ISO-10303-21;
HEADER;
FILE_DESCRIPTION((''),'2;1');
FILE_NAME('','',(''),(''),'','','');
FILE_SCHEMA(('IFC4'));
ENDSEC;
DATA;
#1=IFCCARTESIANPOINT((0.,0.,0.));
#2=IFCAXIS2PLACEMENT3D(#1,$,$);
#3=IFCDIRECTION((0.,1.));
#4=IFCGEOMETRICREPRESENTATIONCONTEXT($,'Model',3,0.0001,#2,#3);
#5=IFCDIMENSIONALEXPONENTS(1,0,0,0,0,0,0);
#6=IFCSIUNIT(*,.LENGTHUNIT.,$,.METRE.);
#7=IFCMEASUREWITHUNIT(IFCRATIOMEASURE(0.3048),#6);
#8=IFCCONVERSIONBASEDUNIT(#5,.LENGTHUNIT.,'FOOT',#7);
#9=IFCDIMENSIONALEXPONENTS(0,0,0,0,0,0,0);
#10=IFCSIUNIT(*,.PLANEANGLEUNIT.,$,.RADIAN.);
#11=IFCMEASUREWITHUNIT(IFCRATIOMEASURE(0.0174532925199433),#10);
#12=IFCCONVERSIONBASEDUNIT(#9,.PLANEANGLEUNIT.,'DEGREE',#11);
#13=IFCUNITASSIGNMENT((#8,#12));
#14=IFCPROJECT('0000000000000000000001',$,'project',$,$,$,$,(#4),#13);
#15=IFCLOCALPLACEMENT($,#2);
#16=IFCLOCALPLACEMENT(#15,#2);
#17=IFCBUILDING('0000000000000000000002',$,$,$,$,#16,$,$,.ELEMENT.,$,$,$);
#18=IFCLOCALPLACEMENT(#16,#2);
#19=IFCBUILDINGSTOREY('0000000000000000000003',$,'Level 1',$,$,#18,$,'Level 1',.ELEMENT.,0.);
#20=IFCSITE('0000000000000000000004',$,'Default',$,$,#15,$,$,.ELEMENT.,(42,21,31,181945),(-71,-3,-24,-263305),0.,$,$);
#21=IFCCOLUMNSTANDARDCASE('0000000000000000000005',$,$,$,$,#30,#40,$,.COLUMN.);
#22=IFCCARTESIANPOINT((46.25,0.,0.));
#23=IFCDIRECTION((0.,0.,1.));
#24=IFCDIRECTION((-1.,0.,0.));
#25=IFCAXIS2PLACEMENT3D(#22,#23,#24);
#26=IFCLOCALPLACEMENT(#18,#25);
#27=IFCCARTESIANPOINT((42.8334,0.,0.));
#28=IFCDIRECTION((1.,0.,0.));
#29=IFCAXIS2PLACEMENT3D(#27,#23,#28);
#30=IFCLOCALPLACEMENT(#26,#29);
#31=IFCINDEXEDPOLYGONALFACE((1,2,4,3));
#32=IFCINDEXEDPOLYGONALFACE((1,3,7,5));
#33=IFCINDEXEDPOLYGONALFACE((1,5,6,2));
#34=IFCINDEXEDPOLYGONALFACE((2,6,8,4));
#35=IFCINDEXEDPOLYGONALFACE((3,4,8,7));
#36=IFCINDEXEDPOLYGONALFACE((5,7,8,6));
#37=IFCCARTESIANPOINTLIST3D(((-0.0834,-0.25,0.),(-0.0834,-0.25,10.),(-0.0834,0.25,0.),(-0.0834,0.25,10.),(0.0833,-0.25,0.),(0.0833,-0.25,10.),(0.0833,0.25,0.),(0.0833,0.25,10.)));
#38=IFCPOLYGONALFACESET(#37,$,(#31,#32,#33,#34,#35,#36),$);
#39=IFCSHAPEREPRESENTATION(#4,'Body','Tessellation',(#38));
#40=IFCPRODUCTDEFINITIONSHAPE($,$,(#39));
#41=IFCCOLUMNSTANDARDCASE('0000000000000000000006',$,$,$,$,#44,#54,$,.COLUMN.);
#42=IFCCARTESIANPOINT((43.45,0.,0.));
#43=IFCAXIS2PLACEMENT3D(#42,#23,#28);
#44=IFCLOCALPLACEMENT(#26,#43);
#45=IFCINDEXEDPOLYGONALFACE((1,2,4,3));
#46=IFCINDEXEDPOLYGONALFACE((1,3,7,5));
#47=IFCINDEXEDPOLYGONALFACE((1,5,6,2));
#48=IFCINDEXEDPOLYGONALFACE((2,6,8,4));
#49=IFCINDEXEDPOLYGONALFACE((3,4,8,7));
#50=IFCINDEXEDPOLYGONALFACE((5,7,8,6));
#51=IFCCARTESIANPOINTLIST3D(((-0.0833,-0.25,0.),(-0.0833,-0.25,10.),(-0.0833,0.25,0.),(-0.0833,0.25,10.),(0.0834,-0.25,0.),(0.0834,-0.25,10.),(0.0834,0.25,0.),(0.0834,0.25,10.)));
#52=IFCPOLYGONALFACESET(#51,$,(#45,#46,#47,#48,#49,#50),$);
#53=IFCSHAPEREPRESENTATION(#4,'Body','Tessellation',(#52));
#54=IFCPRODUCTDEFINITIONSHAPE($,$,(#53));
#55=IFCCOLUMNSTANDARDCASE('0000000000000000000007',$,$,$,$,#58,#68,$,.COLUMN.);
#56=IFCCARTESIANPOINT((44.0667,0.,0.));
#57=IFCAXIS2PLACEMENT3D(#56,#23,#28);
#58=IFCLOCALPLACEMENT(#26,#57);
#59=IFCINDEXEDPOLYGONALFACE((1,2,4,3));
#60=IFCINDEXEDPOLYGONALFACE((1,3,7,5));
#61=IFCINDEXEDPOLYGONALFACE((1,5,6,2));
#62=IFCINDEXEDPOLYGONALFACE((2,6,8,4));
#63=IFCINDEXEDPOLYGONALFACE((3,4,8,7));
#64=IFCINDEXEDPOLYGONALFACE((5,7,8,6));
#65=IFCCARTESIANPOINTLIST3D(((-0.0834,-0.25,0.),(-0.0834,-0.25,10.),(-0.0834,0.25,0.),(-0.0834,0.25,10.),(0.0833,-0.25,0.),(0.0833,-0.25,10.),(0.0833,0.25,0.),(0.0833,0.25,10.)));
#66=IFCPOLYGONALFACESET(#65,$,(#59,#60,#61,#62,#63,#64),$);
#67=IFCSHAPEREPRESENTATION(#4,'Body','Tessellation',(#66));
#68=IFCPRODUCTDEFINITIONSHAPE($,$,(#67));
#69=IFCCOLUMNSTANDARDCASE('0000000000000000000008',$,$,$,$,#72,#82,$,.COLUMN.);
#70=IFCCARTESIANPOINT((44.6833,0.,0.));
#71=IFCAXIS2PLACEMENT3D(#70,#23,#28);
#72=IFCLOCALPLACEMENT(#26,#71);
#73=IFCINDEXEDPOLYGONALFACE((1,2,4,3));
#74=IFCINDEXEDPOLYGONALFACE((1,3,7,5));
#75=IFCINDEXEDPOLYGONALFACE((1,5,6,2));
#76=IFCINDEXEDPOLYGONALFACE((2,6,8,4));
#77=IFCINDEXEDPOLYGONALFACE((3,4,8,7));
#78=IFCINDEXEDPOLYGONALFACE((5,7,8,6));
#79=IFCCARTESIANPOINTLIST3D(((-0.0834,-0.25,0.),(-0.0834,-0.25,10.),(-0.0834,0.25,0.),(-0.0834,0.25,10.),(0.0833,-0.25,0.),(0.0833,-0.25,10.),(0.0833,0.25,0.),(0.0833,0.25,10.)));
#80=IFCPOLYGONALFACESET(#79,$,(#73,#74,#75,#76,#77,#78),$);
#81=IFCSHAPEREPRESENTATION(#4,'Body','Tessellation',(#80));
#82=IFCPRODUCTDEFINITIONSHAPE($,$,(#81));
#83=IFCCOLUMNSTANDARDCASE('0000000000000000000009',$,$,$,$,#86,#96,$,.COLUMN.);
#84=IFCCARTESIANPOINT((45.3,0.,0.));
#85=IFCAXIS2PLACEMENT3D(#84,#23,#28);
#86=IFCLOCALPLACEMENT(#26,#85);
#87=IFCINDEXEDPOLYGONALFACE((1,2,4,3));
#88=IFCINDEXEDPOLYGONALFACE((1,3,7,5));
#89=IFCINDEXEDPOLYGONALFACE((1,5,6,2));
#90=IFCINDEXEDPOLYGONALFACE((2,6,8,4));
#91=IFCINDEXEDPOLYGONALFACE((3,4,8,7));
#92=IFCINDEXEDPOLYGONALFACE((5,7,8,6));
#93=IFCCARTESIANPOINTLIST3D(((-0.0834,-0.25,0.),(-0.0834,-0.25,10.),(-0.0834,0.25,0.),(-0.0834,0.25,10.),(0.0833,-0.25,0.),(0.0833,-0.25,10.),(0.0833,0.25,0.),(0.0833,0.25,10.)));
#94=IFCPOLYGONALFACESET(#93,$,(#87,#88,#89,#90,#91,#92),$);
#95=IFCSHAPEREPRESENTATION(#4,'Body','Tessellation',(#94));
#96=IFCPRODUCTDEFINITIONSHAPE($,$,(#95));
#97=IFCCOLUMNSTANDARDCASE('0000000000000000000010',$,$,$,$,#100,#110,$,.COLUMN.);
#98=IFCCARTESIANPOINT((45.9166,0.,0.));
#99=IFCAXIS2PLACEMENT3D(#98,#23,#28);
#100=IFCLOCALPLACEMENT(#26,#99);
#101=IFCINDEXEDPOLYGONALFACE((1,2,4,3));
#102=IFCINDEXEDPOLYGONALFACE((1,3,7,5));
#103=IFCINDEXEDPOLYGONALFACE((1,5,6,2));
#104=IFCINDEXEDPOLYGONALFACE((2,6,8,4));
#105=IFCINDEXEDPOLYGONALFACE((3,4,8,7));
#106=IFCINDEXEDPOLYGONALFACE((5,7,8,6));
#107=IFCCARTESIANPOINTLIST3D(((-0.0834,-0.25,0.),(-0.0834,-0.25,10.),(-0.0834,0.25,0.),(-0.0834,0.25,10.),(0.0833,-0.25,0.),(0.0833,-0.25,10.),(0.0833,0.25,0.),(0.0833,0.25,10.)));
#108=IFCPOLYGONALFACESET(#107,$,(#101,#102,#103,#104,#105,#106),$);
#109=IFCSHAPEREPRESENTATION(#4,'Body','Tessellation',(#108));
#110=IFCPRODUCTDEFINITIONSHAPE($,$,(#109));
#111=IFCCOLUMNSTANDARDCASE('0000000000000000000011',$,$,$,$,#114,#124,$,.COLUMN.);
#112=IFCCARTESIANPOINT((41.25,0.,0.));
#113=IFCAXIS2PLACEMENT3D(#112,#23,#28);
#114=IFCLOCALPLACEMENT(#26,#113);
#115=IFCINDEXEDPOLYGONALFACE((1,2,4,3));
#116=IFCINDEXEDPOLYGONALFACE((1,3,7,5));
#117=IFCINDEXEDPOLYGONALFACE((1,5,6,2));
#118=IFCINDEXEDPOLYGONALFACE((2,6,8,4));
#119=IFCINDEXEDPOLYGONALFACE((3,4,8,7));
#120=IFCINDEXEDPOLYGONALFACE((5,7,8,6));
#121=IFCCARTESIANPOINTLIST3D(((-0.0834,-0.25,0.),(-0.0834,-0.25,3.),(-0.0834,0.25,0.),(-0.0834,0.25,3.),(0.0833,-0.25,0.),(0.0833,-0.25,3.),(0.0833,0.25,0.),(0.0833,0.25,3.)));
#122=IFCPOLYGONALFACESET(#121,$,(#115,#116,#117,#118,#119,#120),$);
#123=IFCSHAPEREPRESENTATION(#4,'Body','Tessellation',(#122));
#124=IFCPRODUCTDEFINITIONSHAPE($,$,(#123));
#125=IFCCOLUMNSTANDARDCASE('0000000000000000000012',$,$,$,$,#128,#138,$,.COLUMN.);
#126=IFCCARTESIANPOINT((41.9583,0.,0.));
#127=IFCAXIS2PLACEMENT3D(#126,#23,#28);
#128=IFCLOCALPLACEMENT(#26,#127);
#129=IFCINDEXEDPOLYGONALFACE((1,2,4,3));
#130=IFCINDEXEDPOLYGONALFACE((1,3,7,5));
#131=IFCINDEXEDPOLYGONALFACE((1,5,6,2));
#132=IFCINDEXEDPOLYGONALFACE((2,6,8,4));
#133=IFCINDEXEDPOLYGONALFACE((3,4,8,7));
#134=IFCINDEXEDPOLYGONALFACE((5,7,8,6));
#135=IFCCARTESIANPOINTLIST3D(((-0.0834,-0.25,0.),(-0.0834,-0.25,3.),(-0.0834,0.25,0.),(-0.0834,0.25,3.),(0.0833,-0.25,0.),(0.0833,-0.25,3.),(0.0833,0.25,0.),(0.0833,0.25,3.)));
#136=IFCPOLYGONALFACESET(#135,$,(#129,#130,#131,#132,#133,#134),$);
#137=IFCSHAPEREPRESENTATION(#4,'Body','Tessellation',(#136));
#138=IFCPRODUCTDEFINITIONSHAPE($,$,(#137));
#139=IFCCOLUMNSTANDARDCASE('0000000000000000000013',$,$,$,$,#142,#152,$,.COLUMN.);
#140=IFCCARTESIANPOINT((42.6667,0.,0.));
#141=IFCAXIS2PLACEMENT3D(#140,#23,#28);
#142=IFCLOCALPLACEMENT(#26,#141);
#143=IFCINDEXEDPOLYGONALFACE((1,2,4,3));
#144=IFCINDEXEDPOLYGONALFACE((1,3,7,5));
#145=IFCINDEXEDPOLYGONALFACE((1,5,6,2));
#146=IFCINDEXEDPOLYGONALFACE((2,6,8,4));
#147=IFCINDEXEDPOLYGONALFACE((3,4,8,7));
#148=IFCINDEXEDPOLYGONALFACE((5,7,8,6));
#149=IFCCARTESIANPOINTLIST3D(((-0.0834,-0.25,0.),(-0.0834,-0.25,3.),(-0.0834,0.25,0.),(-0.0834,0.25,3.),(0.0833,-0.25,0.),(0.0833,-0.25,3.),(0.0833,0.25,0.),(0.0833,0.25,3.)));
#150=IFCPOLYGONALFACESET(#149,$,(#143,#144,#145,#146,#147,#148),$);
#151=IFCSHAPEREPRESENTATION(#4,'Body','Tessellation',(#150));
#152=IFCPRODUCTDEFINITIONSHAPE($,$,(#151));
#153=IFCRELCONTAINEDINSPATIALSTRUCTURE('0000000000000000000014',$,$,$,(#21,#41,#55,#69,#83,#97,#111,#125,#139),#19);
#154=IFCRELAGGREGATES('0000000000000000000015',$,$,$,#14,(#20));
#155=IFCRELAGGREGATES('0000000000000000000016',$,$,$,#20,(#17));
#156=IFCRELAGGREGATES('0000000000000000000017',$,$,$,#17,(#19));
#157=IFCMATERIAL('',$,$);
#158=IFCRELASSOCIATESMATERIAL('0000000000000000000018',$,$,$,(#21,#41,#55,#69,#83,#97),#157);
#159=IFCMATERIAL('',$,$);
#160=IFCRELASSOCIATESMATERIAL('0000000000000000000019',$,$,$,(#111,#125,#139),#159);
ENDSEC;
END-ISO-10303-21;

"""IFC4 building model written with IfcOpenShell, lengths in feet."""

from ifc_helpers import new_model, entity, si_unit, converted_unit, direction, frame, origin, place, context, project, spatial, rectangle, extrude, material, element, save


model = new_model("IFC4")

# Units and contexts
model_context = context("Model", 3, precision=0.0001, world=origin(), true_north=direction((0.0, 1.0)))
ifc_project = project(units=[converted_unit("LENGTHUNIT", "FOOT", entity("IfcRatioMeasure", 0.3048), si_unit("LENGTHUNIT", "METRE"), dimensions=[1, 0, 0, 0, 0, 0, 0]), converted_unit("PLANEANGLEUNIT", "DEGREE", entity("IfcRatioMeasure", 0.0174532925199433), si_unit("PLANEANGLEUNIT", "RADIAN"), dimensions=[0, 0, 0, 0, 0, 0, 0])], contexts=[model_context])

# Site, building, storey
site_placement = place(None, origin())
site = spatial("IfcSite", under=ifc_project, at=site_placement, Name="Default", CompositionType="ELEMENT", RefLatitude=(42, 21, 31, 181945), RefLongitude=(-71, -3, -24, -263305), RefElevation=0.0)
building_placement = place(site_placement, origin())
building = spatial("IfcBuilding", under=site, at=building_placement, CompositionType="ELEMENT")
storey_placement = place(building_placement, origin())
storey = spatial("IfcBuildingStorey", under=building, at=storey_placement, Name="Level 1", LongName="Level 1", CompositionType="ELEMENT", Elevation=0.0)

# Columns
ifc_material_1 = material(Name="")
placement = place(storey_placement, frame((46.25, 0.0, 0.0), z_axis=(0.0, 0.0, 1.0), x_axis=(-1.0, 0.0, 0.0)))
for number, where, z_axis, x_axis in (
    (1, (42.8334, 0.0, 0.0), (0.0, 0.0, 1.0), (1.0, 0.0, 0.0)),
    (2, (43.45, 0.0, 0.0), (0.0, 0.0, 1.0), (1.0, 0.0, 0.0)),
    (3, (44.0667, 0.0, 0.0), (0.0, 0.0, 1.0), (1.0, 0.0, 0.0)),
    (4, (44.6833, 0.0, 0.0), (0.0, 0.0, 1.0), (1.0, 0.0, 0.0)),
    (5, (45.3, 0.0, 0.0), (0.0, 0.0, 1.0), (1.0, 0.0, 0.0)),
    (6, (45.9166, 0.0, 0.0), (0.0, 0.0, 1.0), (1.0, 0.0, 0.0)),
):
    element("IfcColumnStandardCase", number, at=place(placement, frame(where, z_axis=z_axis, x_axis=x_axis)), inside=storey, material=ifc_material_1, PredefinedType="COLUMN", context=model_context, shape_type="SweptSolid", body=[
        extrude(rectangle(XDim=0.1667, YDim=0.5), origin(), (0.0, 0.0, 1.0), 10.0),
    ])
ifc_material_2 = material(Name="")
for number, where, z_axis, x_axis in (
    (7, (41.25, 0.0, 0.0), (0.0, 0.0, 1.0), (1.0, 0.0, 0.0)),
    (8, (41.9583, 0.0, 0.0), (0.0, 0.0, 1.0), (1.0, 0.0, 0.0)),
    (9, (42.6667, 0.0, 0.0), (0.0, 0.0, 1.0), (1.0, 0.0, 0.0)),
):
    element("IfcColumnStandardCase", number, at=place(placement, frame(where, z_axis=z_axis, x_axis=x_axis)), inside=storey, material=ifc_material_2, PredefinedType="COLUMN", context=model_context, shape_type="SweptSolid", body=[
        extrude(rectangle(XDim=0.1667, YDim=0.5), origin(), (0.0, 0.0, 1.0), 3.0),
    ])

save(model, "model.ifc")
